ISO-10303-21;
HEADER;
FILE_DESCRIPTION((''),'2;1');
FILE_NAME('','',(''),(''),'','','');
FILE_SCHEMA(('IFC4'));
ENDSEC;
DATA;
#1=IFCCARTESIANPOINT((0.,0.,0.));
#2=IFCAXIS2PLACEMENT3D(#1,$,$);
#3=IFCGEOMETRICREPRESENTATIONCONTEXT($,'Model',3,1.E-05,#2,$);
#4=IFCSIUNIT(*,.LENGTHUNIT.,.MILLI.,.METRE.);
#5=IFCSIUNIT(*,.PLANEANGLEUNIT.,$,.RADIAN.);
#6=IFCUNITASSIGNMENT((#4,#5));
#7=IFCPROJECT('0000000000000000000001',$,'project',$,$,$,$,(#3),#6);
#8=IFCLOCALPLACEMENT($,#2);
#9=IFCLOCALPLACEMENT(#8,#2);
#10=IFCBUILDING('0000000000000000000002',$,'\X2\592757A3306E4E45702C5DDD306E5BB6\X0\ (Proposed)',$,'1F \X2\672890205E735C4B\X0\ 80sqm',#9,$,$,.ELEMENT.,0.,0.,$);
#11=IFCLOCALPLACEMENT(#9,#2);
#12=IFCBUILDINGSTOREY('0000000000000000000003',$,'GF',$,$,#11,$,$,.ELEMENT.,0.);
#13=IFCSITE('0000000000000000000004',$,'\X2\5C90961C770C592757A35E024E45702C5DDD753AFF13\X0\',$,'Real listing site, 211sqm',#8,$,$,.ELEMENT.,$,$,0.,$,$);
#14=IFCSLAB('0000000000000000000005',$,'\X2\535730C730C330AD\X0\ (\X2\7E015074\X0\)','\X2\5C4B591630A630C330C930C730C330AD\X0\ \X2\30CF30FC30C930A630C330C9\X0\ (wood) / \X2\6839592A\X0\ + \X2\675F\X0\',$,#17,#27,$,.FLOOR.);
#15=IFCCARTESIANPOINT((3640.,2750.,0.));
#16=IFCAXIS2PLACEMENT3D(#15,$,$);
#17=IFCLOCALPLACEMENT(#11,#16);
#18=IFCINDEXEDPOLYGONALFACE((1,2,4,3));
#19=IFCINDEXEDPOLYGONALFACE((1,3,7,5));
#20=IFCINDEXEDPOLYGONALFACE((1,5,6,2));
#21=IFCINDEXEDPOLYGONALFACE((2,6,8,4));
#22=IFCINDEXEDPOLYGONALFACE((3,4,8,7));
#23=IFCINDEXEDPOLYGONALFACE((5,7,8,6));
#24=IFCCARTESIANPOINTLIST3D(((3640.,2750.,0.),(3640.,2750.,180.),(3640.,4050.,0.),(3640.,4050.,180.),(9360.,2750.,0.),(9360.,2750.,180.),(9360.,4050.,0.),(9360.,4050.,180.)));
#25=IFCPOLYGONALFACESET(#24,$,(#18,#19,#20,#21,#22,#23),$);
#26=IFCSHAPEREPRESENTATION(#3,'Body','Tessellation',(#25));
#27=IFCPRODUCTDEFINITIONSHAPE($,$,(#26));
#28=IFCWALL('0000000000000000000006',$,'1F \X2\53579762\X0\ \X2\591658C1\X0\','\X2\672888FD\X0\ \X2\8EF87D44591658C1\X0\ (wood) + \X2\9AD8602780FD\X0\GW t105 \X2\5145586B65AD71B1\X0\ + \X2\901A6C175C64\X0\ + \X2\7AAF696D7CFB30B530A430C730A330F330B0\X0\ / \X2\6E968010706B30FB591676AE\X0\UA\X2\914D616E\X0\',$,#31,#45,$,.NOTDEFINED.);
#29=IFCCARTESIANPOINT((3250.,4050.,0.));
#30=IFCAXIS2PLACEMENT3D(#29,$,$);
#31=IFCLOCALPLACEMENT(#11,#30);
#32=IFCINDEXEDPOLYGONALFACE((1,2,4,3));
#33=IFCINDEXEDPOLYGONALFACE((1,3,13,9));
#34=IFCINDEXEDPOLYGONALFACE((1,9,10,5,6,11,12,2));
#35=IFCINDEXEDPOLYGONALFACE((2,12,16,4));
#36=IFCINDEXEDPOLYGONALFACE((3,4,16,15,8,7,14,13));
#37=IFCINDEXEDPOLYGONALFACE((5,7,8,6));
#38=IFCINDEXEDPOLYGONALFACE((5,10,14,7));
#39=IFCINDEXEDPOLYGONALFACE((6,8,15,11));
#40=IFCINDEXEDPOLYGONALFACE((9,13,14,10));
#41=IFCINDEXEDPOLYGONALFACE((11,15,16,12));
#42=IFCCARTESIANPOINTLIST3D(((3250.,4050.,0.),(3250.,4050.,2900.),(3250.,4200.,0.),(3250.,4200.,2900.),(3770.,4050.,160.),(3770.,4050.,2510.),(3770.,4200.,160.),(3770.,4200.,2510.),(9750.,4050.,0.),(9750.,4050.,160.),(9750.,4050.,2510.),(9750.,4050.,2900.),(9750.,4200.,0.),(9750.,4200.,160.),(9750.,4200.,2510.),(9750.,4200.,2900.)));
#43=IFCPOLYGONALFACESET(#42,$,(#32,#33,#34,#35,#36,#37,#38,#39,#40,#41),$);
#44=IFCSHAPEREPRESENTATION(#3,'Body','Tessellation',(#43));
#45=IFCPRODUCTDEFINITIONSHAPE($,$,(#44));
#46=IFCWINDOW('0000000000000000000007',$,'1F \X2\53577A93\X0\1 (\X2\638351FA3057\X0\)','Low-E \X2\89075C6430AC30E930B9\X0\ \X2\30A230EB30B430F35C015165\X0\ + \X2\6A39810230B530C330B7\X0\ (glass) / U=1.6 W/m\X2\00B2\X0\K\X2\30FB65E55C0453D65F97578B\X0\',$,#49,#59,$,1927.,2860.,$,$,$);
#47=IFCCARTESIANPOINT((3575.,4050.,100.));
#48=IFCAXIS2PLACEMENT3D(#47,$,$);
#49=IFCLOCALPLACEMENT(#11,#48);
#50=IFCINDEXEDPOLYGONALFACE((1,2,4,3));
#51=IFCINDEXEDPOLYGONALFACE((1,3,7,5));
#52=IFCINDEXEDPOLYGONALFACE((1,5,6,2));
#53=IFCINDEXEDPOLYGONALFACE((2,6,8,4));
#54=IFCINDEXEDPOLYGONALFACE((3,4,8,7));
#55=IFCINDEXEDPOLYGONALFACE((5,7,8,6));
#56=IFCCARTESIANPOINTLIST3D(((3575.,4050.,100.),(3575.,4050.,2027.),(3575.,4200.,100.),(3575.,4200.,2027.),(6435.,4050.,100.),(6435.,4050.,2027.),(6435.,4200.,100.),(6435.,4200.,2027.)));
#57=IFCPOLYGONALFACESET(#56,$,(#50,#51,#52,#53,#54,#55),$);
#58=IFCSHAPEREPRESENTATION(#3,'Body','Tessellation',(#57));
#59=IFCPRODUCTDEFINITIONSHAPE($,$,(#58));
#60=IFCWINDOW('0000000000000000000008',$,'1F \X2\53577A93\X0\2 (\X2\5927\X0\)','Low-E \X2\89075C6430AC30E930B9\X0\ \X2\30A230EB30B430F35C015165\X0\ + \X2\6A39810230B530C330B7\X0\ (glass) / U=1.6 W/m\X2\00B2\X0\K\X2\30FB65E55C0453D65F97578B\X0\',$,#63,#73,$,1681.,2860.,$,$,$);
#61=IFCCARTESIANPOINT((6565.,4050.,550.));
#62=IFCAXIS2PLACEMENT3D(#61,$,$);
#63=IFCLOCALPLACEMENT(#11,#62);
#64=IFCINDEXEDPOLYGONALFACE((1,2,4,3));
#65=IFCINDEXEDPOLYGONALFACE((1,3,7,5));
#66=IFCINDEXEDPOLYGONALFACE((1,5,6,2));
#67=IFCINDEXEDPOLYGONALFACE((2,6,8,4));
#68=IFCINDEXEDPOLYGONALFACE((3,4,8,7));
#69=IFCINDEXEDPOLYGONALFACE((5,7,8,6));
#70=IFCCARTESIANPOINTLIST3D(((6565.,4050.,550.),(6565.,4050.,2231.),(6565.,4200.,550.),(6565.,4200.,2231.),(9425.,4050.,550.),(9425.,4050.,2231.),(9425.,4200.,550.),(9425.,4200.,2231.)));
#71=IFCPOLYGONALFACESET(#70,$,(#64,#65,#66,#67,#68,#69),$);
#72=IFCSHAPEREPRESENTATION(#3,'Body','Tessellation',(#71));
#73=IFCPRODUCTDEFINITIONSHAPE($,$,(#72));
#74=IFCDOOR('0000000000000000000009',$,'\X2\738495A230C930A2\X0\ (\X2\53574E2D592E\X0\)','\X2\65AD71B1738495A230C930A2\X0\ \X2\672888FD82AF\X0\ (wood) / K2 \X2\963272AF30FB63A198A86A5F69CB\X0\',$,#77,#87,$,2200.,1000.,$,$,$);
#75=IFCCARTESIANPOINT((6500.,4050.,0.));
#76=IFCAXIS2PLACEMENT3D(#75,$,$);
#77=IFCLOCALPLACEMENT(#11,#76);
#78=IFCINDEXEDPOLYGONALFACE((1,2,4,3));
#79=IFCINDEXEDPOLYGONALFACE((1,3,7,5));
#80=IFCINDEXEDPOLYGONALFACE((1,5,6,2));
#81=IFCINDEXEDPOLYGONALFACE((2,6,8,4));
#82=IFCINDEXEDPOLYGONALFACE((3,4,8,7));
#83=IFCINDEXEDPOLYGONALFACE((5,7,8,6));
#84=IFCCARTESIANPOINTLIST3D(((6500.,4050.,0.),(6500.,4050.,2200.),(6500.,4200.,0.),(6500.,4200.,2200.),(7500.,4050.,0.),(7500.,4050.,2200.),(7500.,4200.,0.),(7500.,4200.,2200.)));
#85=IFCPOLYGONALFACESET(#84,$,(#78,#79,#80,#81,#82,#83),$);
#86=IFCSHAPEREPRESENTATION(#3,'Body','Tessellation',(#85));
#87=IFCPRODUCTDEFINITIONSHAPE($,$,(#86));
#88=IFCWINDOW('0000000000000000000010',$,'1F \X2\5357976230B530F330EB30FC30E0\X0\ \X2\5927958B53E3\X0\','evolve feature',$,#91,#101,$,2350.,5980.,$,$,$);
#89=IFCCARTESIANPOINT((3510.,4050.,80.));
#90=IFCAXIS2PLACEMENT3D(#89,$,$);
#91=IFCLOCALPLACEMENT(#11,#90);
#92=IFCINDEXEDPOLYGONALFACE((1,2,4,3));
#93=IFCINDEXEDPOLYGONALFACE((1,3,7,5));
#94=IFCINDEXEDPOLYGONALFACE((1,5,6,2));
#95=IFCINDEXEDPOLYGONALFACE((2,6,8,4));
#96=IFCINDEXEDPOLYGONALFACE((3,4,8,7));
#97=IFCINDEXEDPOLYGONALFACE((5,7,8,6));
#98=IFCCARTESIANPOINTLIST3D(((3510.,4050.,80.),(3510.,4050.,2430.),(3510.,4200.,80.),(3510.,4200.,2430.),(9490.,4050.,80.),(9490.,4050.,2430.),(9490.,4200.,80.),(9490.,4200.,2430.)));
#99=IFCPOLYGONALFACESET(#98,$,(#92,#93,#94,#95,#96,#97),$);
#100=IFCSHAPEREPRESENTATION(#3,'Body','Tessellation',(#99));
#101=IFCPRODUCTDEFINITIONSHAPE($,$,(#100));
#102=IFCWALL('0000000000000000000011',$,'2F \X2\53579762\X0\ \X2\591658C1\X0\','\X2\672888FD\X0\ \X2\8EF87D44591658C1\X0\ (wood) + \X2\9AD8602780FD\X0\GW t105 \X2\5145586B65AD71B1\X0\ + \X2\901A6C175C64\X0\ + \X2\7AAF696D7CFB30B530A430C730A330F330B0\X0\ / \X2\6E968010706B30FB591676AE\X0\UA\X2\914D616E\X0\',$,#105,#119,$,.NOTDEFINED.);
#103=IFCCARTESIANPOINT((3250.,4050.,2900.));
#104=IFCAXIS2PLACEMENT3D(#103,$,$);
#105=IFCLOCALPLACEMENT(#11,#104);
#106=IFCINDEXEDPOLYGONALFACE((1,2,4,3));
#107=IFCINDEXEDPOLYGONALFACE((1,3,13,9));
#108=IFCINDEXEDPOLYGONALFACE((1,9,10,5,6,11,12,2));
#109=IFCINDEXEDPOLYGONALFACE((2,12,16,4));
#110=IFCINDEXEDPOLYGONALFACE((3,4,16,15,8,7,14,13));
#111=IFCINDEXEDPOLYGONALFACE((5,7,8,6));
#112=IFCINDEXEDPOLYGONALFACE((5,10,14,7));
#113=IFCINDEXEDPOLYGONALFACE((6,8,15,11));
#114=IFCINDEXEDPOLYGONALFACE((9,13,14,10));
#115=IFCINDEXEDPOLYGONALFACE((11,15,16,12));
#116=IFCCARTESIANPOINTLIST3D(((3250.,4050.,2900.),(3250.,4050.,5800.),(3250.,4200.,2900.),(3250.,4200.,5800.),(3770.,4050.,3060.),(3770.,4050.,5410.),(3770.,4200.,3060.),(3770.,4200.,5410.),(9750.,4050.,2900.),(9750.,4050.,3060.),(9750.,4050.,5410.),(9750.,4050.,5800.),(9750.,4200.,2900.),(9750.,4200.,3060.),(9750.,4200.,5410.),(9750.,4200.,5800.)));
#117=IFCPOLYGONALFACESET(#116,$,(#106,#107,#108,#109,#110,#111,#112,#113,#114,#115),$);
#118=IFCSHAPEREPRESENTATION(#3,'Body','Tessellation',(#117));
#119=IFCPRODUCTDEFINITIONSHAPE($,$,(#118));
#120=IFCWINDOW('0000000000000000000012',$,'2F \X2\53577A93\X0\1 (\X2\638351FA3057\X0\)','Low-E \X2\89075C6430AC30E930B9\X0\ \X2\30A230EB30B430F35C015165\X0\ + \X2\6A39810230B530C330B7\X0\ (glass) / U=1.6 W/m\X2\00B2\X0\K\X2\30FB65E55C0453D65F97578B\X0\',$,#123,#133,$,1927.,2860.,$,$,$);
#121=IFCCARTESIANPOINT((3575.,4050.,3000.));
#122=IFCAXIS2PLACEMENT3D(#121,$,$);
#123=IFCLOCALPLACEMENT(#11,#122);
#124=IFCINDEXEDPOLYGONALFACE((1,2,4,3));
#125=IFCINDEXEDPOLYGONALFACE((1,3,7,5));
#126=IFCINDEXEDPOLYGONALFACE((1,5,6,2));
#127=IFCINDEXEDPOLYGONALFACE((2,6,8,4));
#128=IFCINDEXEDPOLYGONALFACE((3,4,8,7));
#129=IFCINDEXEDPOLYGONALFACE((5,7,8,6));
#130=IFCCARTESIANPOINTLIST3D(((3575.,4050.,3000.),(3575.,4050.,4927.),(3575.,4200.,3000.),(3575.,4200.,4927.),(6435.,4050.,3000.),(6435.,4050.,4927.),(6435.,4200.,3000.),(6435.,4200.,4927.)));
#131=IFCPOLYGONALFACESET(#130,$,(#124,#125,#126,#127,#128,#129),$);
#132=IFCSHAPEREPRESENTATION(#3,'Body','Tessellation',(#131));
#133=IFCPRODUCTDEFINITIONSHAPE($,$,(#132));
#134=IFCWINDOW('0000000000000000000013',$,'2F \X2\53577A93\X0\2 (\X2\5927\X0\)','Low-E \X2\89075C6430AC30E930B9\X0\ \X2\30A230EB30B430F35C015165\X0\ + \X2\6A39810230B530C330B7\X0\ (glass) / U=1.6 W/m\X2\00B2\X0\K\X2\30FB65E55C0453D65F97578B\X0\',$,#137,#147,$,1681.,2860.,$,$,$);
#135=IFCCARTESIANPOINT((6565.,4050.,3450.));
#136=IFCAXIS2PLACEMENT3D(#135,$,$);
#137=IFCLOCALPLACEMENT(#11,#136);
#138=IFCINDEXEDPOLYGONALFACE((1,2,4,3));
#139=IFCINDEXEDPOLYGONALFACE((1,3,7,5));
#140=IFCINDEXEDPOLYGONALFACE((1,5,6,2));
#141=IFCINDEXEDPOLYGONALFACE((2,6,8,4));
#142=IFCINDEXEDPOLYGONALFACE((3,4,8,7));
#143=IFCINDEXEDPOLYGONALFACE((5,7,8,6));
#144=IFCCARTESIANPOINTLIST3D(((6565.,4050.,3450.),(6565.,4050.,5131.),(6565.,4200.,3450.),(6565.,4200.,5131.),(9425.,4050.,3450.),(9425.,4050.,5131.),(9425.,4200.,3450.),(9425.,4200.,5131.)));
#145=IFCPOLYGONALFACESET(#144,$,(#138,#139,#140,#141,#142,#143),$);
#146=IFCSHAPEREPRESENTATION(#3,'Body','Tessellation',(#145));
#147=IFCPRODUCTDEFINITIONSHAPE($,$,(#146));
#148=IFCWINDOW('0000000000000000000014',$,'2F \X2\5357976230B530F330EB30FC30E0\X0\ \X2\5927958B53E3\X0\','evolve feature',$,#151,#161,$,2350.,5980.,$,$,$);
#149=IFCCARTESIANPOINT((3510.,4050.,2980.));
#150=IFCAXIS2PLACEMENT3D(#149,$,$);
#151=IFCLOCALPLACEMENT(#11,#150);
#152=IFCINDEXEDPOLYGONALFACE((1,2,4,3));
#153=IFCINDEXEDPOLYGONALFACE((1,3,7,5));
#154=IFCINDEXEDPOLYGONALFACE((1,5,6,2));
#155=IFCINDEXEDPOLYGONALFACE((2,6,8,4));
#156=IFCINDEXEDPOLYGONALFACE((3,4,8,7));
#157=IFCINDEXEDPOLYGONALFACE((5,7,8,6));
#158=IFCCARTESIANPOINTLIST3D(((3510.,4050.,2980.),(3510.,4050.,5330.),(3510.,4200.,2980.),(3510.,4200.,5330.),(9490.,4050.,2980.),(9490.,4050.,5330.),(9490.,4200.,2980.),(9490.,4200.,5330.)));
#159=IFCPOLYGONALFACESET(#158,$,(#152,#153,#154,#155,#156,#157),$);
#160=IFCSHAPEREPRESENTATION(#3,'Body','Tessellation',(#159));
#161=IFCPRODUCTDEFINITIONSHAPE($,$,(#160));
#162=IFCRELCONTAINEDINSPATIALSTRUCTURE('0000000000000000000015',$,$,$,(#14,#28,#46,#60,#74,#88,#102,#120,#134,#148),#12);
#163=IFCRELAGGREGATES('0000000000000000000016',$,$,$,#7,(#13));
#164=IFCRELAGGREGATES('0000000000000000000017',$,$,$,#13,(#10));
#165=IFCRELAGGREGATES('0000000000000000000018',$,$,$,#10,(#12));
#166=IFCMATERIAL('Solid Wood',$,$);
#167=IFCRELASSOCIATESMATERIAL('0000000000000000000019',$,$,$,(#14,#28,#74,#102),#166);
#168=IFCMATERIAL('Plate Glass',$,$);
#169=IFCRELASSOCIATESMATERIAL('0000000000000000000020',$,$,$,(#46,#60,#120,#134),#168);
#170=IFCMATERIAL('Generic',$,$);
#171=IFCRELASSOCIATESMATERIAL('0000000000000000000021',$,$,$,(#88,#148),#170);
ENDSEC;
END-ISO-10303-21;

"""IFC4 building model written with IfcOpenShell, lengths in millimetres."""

from ifc_helpers import new_model, si_unit, frame, frame_2d, origin, place, context, project, spatial, rectangle, extrude, material, element, fill, save


model = new_model("IFC4")

# Units and contexts
model_context = context("Model", 3, precision=1e-05, world=origin())
ifc_project = project(units=[si_unit("LENGTHUNIT", "METRE", prefix="MILLI"), si_unit("PLANEANGLEUNIT", "RADIAN")], contexts=[model_context])

# Site, building, storey
site_placement = place(None, origin())
site = spatial("IfcSite", under=ifc_project, at=site_placement, Name="岐阜県大垣市久瀬川町３", ObjectType="Real listing site, 211sqm", CompositionType="ELEMENT", RefElevation=0.0)
building_placement = place(site_placement, origin())
building = spatial("IfcBuilding", under=site, at=building_placement, Name="大垣の久瀬川の家 (Proposed)", ObjectType="1F 木造平屋 80sqm", CompositionType="ELEMENT", ElevationOfRefHeight=0.0, ElevationOfTerrain=0.0)
storey_placement = place(building_placement, origin())
storey = spatial("IfcBuildingStorey", under=building, at=storey_placement, Name="GF", CompositionType="ELEMENT", Elevation=0.0)

# Slab
ifc_material_1 = material(Name="Solid Wood")
slab_1_placement = place(storey_placement, frame((3640.0, 2750.0, 0.0)))
element("IfcSlab", 1, at=slab_1_placement, inside=storey, material=ifc_material_1, Name="南デッキ (縁側)", Description="屋外ウッドデッキ ハードウッド (wood) / 根太 + 束", PredefinedType="FLOOR", context=model_context, shape_type="SweptSolid", body=[
    extrude(rectangle(XDim=5720.0, YDim=1300.0, at=frame_2d((2860.0, 650.0))), frame((3640.0, 2750.0, 0.0)), (0.0, 0.0, 1.0), 180.0),
])
ifc_material_2 = material(Name="Generic")

# Wall, openings, windows, door
wall_1_placement = place(storey_placement, frame((3250.0, 4050.0, 0.0)))
wall_1 = element("IfcWall", 2, at=wall_1_placement, inside=storey, material=ifc_material_1, Name="1F 南面 外壁", Description="木製 軸組外壁 (wood) + 高性能GW t105 充填断熱 + 通気層 + 窯業系サイディング / 準耐火・外皮UA配慮", PredefinedType="NOTDEFINED", context=model_context, shape_type="SweptSolid", body=[
    extrude(rectangle(XDim=6500.0, YDim=150.0, at=frame_2d((3250.0, 75.0))), frame((3250.0, 4050.0, 0.0)), (0.0, 0.0, 1.0), 2900.0),
])
opening_1_placement = place(storey_placement, frame((3575.0, 4050.0, 100.0)))
opening_1 = element("IfcOpeningElement", 3, at=opening_1_placement, cuts=wall_1, PredefinedType="NOTDEFINED", context=model_context, shape_type="SweptSolid", body=[
    extrude(rectangle(XDim=2860.0, YDim=150.0, at=frame_2d((1430.0, 75.0))), frame((3575.0, 4050.0, 100.0)), (0.0, 0.0, 1.0), 1927.0),
])
opening_2_placement = place(storey_placement, frame((6565.0, 4050.0, 550.0)))
opening_2 = element("IfcOpeningElement", 4, at=opening_2_placement, cuts=wall_1, PredefinedType="NOTDEFINED", context=model_context, shape_type="SweptSolid", body=[
    extrude(rectangle(XDim=2860.0, YDim=150.0, at=frame_2d((1430.0, 75.0))), frame((6565.0, 4050.0, 550.0)), (0.0, 0.0, 1.0), 1681.0),
])
opening_3_placement = place(storey_placement, frame((6500.0, 4050.0, 0.0)))
opening_3 = element("IfcOpeningElement", 5, at=opening_3_placement, cuts=wall_1, PredefinedType="NOTDEFINED", context=model_context, shape_type="SweptSolid", body=[
    extrude(rectangle(XDim=1000.0, YDim=150.0, at=frame_2d((500.0, 75.0))), frame((6500.0, 4050.0, 0.0)), (0.0, 0.0, 1.0), 2200.0),
])
opening_4_placement = place(storey_placement, frame((3510.0, 4050.0, 80.0)))
opening_4 = element("IfcOpeningElement", 6, at=opening_4_placement, cuts=wall_1, PredefinedType="NOTDEFINED", context=model_context, shape_type="SweptSolid", body=[
    extrude(rectangle(XDim=5980.0, YDim=150.0, at=frame_2d((2990.0, 75.0))), frame((3510.0, 4050.0, 80.0)), (0.0, 0.0, 1.0), 2350.0),
])
ifc_material_3 = material(Name="Plate Glass")
window_1_placement = place(storey_placement, frame((3575.0, 4050.0, 100.0)))
window_1 = element("IfcWindow", 7, at=window_1_placement, inside=storey, material=ifc_material_3, Name="1F 南窓1 (掃出し)", Description="Low-E 複層ガラス アルゴン封入 + 樹脂サッシ (glass) / U=1.6 W/m²K・日射取得型", OverallHeight=1927.0, OverallWidth=2860.0, context=model_context, shape_type="SweptSolid", body=[
    extrude(rectangle(XDim=2860.0, YDim=150.0, at=frame_2d((1430.0, 75.0))), frame((3575.0, 4050.0, 100.0)), (0.0, 0.0, 1.0), 1927.0),
])
fill(opening_1, window_1)
window_2_placement = place(storey_placement, frame((6565.0, 4050.0, 550.0)))
window_2 = element("IfcWindow", 8, at=window_2_placement, inside=storey, material=ifc_material_3, Name="1F 南窓2 (大)", Description="Low-E 複層ガラス アルゴン封入 + 樹脂サッシ (glass) / U=1.6 W/m²K・日射取得型", OverallHeight=1681.0, OverallWidth=2860.0, context=model_context, shape_type="SweptSolid", body=[
    extrude(rectangle(XDim=2860.0, YDim=150.0, at=frame_2d((1430.0, 75.0))), frame((6565.0, 4050.0, 550.0)), (0.0, 0.0, 1.0), 1681.0),
])
fill(opening_2, window_2)
door_placement = place(storey_placement, frame((6500.0, 4050.0, 0.0)))
door = element("IfcDoor", 9, at=door_placement, inside=storey, material=ifc_material_1, Name="玄関ドア (南中央)", Description="断熱玄関ドア 木製芯 (wood) / K2 防犯・採風機構", OverallHeight=2200.0, OverallWidth=1000.0, context=model_context, shape_type="SweptSolid", body=[
    extrude(rectangle(XDim=1000.0, YDim=150.0, at=frame_2d((500.0, 75.0))), frame((6500.0, 4050.0, 0.0)), (0.0, 0.0, 1.0), 2200.0),
])
fill(opening_3, door)
window_3_placement = place(storey_placement, frame((3510.0, 4050.0, 80.0)))
window_3 = element("IfcWindow", 10, at=window_3_placement, inside=storey, material=ifc_material_2, Name="1F 南面サンルーム 大開口", Description="evolve feature", OverallHeight=2350.0, OverallWidth=5980.0, context=model_context, shape_type="SweptSolid", body=[
    extrude(rectangle(XDim=5980.0, YDim=150.0, at=frame_2d((2990.0, 75.0))), frame((3510.0, 4050.0, 80.0)), (0.0, 0.0, 1.0), 2350.0),
])
fill(opening_4, window_3)

# Wall, openings, windows
wall_2_placement = place(storey_placement, frame((3250.0, 4050.0, 2900.0)))
wall_2 = element("IfcWall", 11, at=wall_2_placement, inside=storey, material=ifc_material_1, Name="2F 南面 外壁", Description="木製 軸組外壁 (wood) + 高性能GW t105 充填断熱 + 通気層 + 窯業系サイディング / 準耐火・外皮UA配慮", PredefinedType="NOTDEFINED", context=model_context, shape_type="SweptSolid", body=[
    extrude(rectangle(XDim=6500.0, YDim=150.0, at=frame_2d((3250.0, 75.0))), frame((3250.0, 4050.0, 2900.0)), (0.0, 0.0, 1.0), 2900.0),
])
opening_5_placement = place(storey_placement, frame((3575.0, 4050.0, 3000.0)))
opening_5 = element("IfcOpeningElement", 12, at=opening_5_placement, cuts=wall_2, PredefinedType="NOTDEFINED", context=model_context, shape_type="SweptSolid", body=[
    extrude(rectangle(XDim=2860.0, YDim=150.0, at=frame_2d((1430.0, 75.0))), frame((3575.0, 4050.0, 3000.0)), (0.0, 0.0, 1.0), 1927.0),
])
opening_6_placement = place(storey_placement, frame((6565.0, 4050.0, 3450.0)))
opening_6 = element("IfcOpeningElement", 13, at=opening_6_placement, cuts=wall_2, PredefinedType="NOTDEFINED", context=model_context, shape_type="SweptSolid", body=[
    extrude(rectangle(XDim=2860.0, YDim=150.0, at=frame_2d((1430.0, 75.0))), frame((6565.0, 4050.0, 3450.0)), (0.0, 0.0, 1.0), 1681.0),
])
opening_7_placement = place(storey_placement, frame((3510.0, 4050.0, 2980.0)))
opening_7 = element("IfcOpeningElement", 14, at=opening_7_placement, cuts=wall_2, PredefinedType="NOTDEFINED", context=model_context, shape_type="SweptSolid", body=[
    extrude(rectangle(XDim=5980.0, YDim=150.0, at=frame_2d((2990.0, 75.0))), frame((3510.0, 4050.0, 2980.0)), (0.0, 0.0, 1.0), 2350.0),
])
window_4_placement = place(storey_placement, frame((3575.0, 4050.0, 3000.0)))
window_4 = element("IfcWindow", 15, at=window_4_placement, inside=storey, material=ifc_material_3, Name="2F 南窓1 (掃出し)", Description="Low-E 複層ガラス アルゴン封入 + 樹脂サッシ (glass) / U=1.6 W/m²K・日射取得型", OverallHeight=1927.0, OverallWidth=2860.0, context=model_context, shape_type="SweptSolid", body=[
    extrude(rectangle(XDim=2860.0, YDim=150.0, at=frame_2d((1430.0, 75.0))), frame((3575.0, 4050.0, 3000.0)), (0.0, 0.0, 1.0), 1927.0),
])
fill(opening_5, window_4)
window_5_placement = place(storey_placement, frame((6565.0, 4050.0, 3450.0)))
window_5 = element("IfcWindow", 16, at=window_5_placement, inside=storey, material=ifc_material_3, Name="2F 南窓2 (大)", Description="Low-E 複層ガラス アルゴン封入 + 樹脂サッシ (glass) / U=1.6 W/m²K・日射取得型", OverallHeight=1681.0, OverallWidth=2860.0, context=model_context, shape_type="SweptSolid", body=[
    extrude(rectangle(XDim=2860.0, YDim=150.0, at=frame_2d((1430.0, 75.0))), frame((6565.0, 4050.0, 3450.0)), (0.0, 0.0, 1.0), 1681.0),
])
fill(opening_6, window_5)
window_6_placement = place(storey_placement, frame((3510.0, 4050.0, 2980.0)))
window_6 = element("IfcWindow", 17, at=window_6_placement, inside=storey, material=ifc_material_2, Name="2F 南面サンルーム 大開口", Description="evolve feature", OverallHeight=2350.0, OverallWidth=5980.0, context=model_context, shape_type="SweptSolid", body=[
    extrude(rectangle(XDim=5980.0, YDim=150.0, at=frame_2d((2990.0, 75.0))), frame((3510.0, 4050.0, 2980.0)), (0.0, 0.0, 1.0), 2350.0),
])
fill(opening_7, window_6)

save(model, "model.ifc")
